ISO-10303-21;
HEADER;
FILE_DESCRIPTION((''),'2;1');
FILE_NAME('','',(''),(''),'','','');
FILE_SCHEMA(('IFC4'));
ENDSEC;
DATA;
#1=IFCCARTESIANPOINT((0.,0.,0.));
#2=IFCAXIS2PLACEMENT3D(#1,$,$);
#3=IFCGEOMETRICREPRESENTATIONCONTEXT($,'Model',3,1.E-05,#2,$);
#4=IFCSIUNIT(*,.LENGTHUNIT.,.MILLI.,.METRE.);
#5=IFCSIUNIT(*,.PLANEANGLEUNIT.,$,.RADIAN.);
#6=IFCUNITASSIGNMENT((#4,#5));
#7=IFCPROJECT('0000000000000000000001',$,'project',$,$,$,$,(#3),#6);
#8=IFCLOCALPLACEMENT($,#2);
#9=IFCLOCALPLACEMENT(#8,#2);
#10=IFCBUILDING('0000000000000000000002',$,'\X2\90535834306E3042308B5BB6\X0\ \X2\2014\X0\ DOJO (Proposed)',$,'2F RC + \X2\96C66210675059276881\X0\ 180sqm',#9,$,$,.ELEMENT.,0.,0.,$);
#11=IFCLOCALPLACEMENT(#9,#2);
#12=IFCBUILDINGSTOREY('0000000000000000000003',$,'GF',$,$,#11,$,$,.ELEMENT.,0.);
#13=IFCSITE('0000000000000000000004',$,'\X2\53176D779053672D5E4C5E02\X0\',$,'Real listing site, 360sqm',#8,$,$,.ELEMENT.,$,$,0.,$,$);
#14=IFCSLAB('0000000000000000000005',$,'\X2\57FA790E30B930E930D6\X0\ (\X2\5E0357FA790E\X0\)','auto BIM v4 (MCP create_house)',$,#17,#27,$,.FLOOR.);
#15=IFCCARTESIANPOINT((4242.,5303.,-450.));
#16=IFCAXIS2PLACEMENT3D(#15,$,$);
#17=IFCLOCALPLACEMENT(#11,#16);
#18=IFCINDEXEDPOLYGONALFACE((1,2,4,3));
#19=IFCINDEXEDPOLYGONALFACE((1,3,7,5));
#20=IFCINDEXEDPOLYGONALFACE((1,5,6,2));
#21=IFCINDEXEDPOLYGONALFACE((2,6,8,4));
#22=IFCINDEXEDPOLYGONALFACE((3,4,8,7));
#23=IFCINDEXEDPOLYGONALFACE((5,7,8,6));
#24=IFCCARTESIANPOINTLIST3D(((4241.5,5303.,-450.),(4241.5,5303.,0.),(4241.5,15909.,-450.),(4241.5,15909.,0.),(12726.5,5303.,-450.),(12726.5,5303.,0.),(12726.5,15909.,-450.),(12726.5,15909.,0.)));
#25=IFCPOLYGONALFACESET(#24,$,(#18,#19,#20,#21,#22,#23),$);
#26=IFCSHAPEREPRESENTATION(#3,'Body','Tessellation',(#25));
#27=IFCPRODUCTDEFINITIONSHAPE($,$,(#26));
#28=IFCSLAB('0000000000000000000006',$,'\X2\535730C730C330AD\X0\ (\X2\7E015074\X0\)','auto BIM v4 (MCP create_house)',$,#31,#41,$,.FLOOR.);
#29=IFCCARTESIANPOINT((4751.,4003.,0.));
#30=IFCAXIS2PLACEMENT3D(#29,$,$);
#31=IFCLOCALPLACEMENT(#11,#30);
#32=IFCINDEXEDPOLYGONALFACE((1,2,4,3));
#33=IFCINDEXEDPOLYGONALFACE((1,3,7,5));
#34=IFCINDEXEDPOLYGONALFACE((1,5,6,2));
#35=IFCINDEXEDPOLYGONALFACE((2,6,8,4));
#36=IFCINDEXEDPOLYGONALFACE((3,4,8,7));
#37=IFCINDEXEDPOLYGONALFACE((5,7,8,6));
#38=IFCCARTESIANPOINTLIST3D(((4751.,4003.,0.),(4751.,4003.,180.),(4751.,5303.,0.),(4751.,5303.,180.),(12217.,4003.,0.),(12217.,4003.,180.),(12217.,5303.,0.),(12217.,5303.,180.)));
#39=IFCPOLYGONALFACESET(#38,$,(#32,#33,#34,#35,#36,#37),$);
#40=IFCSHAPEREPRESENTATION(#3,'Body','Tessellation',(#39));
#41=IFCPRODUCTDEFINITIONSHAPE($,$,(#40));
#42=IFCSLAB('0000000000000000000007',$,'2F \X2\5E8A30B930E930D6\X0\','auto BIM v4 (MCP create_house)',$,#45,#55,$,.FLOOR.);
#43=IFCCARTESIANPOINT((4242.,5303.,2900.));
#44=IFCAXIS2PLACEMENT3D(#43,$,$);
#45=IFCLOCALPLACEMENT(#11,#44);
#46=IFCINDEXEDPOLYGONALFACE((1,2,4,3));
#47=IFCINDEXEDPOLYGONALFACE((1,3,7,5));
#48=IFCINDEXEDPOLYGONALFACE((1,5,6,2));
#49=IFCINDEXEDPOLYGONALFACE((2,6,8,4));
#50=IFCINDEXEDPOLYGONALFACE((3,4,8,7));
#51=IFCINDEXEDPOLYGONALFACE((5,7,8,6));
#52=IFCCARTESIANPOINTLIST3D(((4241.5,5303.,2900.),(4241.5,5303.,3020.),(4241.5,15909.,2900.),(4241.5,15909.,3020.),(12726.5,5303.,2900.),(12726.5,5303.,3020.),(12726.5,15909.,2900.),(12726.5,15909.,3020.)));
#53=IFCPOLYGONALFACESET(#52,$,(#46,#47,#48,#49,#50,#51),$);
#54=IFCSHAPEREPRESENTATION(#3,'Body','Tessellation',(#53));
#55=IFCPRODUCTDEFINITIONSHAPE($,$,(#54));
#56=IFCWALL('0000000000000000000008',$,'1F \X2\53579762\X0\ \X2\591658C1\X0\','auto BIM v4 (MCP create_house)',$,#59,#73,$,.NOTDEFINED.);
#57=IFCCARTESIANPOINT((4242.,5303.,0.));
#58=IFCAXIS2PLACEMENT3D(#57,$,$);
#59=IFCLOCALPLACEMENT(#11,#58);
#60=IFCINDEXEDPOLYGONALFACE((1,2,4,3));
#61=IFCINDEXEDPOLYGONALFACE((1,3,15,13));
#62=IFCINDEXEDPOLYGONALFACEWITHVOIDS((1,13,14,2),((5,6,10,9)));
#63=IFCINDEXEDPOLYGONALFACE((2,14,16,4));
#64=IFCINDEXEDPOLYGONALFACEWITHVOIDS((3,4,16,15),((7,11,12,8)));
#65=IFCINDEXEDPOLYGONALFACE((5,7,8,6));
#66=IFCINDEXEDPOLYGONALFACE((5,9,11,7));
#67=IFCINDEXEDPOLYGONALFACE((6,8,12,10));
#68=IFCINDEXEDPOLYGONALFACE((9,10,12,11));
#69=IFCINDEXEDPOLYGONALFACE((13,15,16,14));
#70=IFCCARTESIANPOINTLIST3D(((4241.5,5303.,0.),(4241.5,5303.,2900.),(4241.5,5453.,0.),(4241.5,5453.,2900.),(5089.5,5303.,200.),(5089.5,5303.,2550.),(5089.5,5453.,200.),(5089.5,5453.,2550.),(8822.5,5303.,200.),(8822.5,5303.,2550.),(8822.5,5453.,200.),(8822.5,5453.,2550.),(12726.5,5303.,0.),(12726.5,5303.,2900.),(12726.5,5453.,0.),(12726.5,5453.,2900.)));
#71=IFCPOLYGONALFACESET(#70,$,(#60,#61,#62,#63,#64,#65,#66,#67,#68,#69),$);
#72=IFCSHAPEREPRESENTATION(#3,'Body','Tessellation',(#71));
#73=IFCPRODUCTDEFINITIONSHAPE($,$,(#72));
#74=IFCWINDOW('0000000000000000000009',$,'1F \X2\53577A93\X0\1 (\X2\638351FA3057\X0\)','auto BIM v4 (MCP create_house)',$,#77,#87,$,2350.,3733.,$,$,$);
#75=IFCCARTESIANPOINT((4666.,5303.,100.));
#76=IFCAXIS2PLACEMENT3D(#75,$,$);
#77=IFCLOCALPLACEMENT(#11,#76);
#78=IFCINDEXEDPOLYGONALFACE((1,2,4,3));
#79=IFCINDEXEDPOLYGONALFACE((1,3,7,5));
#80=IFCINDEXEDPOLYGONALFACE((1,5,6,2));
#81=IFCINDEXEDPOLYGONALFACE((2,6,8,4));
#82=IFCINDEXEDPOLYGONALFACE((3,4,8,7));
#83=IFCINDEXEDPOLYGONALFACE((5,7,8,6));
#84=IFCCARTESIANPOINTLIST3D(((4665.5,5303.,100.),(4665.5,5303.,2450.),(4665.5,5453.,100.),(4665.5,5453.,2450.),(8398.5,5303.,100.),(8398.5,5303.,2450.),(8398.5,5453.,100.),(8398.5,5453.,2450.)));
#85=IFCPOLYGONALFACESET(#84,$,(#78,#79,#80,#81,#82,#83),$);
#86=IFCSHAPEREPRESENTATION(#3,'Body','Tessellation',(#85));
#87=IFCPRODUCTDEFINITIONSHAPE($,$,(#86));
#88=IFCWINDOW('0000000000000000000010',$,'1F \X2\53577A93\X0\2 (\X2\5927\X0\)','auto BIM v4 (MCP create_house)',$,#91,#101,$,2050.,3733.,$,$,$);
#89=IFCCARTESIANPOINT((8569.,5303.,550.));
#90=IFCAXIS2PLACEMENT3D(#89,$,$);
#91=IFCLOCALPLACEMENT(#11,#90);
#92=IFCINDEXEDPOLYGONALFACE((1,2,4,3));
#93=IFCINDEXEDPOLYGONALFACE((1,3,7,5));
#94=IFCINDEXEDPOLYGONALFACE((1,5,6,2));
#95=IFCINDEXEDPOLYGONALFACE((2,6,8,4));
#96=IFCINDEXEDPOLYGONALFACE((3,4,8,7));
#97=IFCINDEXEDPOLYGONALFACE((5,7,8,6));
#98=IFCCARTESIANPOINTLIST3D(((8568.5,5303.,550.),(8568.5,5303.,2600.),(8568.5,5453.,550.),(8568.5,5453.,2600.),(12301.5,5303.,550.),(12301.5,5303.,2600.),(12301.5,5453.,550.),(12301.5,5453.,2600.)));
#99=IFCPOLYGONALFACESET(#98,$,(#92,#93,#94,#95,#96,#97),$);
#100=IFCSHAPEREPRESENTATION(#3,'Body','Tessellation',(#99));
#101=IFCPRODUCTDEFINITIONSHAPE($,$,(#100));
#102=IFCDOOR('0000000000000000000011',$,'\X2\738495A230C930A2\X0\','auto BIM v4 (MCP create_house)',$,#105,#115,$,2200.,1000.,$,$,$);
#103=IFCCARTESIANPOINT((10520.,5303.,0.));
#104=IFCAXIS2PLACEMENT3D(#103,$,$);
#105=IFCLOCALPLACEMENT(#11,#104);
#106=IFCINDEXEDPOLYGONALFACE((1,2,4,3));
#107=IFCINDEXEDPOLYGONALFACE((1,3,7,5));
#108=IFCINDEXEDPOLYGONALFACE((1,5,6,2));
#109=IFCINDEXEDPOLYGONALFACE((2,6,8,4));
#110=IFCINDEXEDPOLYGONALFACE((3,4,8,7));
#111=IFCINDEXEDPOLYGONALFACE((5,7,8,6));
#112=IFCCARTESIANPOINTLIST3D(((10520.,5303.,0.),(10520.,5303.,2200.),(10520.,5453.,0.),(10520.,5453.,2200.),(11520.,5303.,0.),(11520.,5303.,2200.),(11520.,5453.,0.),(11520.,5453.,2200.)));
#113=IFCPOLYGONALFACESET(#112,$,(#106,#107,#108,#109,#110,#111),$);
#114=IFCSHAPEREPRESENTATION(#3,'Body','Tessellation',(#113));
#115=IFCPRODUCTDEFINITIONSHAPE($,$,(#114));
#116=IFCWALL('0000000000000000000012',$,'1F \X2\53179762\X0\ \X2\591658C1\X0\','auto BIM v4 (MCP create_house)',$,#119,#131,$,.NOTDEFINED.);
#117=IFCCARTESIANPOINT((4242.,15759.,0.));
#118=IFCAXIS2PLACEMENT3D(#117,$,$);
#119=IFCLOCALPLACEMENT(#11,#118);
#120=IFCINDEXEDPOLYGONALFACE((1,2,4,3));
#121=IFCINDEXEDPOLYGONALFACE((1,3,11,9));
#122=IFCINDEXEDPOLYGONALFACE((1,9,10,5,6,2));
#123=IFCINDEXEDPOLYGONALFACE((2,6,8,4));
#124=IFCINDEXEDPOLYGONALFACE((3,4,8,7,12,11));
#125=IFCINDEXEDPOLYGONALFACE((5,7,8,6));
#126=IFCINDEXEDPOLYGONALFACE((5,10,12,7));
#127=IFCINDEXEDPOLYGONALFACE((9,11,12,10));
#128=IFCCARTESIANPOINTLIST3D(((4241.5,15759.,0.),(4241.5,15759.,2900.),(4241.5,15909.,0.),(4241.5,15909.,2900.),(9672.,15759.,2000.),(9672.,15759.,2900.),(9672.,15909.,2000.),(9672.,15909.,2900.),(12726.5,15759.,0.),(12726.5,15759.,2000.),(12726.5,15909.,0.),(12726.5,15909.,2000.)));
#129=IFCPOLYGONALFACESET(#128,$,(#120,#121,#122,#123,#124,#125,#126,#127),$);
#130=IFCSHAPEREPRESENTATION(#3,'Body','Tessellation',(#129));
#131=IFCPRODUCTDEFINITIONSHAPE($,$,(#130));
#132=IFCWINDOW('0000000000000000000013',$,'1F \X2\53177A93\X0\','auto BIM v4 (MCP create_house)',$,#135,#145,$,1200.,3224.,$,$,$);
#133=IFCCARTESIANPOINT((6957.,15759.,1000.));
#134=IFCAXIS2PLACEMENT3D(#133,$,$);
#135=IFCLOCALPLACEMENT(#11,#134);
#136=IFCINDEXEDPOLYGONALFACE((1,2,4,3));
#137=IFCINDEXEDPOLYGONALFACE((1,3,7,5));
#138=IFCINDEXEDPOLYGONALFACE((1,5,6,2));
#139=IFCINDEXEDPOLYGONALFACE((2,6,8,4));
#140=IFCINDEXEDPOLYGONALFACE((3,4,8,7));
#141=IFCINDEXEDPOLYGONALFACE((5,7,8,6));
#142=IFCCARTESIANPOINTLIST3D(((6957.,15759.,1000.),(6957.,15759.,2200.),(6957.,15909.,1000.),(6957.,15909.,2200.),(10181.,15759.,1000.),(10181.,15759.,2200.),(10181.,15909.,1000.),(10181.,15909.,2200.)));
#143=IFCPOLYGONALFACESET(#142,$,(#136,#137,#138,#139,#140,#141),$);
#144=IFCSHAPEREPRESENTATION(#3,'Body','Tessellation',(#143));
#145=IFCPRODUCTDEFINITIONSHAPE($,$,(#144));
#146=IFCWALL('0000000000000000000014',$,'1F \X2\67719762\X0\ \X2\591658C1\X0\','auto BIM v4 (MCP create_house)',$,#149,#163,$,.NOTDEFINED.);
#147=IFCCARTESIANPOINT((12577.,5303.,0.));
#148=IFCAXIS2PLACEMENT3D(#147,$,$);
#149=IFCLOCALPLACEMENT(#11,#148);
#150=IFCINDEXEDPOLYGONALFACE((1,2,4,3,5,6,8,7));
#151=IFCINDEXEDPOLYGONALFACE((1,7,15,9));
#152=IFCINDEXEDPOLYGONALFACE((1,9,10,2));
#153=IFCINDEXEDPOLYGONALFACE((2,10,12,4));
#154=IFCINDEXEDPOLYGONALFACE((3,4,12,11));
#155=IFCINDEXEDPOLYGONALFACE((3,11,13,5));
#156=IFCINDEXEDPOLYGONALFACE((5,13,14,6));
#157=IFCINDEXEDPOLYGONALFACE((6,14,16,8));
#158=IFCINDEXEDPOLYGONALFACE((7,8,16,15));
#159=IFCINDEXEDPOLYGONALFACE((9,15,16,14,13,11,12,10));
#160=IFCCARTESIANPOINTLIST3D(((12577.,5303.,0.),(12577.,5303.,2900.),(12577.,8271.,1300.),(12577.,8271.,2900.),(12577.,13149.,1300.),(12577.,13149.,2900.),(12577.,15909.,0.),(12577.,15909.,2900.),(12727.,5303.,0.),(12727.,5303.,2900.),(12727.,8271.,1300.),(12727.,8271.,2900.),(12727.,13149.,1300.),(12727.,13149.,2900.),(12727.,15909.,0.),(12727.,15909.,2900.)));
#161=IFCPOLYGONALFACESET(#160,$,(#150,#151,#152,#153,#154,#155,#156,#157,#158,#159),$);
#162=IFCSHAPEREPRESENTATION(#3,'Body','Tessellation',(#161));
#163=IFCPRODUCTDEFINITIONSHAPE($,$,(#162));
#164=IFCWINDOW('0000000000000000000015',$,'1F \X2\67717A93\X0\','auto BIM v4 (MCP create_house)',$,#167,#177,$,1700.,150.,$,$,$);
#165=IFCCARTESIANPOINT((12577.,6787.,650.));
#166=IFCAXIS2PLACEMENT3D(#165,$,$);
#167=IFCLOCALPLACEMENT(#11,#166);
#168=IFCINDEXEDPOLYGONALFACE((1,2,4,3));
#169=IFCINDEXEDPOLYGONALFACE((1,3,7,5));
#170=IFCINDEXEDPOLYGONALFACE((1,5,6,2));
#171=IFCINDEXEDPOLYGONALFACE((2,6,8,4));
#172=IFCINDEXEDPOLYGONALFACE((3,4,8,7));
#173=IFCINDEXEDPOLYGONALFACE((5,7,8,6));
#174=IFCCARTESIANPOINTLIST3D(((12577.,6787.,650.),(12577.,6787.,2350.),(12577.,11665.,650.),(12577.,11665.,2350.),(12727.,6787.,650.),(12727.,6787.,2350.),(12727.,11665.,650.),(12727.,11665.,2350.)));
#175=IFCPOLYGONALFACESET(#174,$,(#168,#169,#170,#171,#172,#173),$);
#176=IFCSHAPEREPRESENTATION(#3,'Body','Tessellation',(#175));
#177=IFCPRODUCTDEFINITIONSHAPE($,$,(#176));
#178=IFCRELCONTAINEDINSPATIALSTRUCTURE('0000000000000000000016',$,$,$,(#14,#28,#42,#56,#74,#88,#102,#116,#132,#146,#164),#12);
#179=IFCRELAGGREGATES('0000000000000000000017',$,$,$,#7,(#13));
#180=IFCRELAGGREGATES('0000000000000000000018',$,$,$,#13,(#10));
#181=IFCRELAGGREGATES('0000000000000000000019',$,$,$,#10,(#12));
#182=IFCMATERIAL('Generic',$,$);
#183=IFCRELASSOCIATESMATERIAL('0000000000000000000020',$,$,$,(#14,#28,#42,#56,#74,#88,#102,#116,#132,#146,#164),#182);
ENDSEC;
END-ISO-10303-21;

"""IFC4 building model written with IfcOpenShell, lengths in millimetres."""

from ifc_helpers import new_model, si_unit, frame, frame_2d, origin, place, context, project, spatial, rectangle, extrude, material, element, fill, save


model = new_model("IFC4")

# Units and contexts
model_context = context("Model", 3, precision=1e-05, world=origin())
ifc_project = project(units=[si_unit("LENGTHUNIT", "METRE", prefix="MILLI"), si_unit("PLANEANGLEUNIT", "RADIAN")], contexts=[model_context])

# Site, building, storey
site_placement = place(None, origin())
site = spatial("IfcSite", under=ifc_project, at=site_placement, Name="北海道札幌市", ObjectType="Real listing site, 360sqm", CompositionType="ELEMENT", RefElevation=0.0)
building_placement = place(site_placement, origin())
building = spatial("IfcBuilding", under=site, at=building_placement, Name="道場のある家 — DOJO (Proposed)", ObjectType="2F RC + 集成材大梁 180sqm", CompositionType="ELEMENT", ElevationOfRefHeight=0.0, ElevationOfTerrain=0.0)
storey_placement = place(building_placement, origin())
storey = spatial("IfcBuildingStorey", under=building, at=storey_placement, Name="GF", CompositionType="ELEMENT", Elevation=0.0)

# Slabs
ifc_material = material(Name="Generic")
slab_1_placement = place(storey_placement, frame((4242.0, 5303.0, -450.0)))
element("IfcSlab", 1, at=slab_1_placement, inside=storey, material=ifc_material, Name="基礎スラブ (布基礎)", Description="auto BIM v4 (MCP create_house)", PredefinedType="FLOOR", context=model_context, shape_type="SweptSolid", body=[
    extrude(rectangle(XDim=8485.0, YDim=10606.0, at=frame_2d((4242.0, 5303.0))), frame((4242.0, 5303.0, -450.0)), (0.0, 0.0, 1.0), 450.0),
])
slab_2_placement = place(storey_placement, frame((4751.0, 4003.0, 0.0)))
element("IfcSlab", 2, at=slab_2_placement, inside=storey, material=ifc_material, Name="南デッキ (縁側)", Description="auto BIM v4 (MCP create_house)", PredefinedType="FLOOR", context=model_context, shape_type="SweptSolid", body=[
    extrude(rectangle(XDim=7466.0, YDim=1300.0, at=frame_2d((3733.0, 650.0))), frame((4751.0, 4003.0, 0.0)), (0.0, 0.0, 1.0), 180.0),
])
slab_3_placement = place(storey_placement, frame((4242.0, 5303.0, 2900.0)))
element("IfcSlab", 3, at=slab_3_placement, inside=storey, material=ifc_material, Name="2F 床スラブ", Description="auto BIM v4 (MCP create_house)", PredefinedType="FLOOR", context=model_context, shape_type="SweptSolid", body=[
    extrude(rectangle(XDim=8485.0, YDim=10606.0, at=frame_2d((4242.0, 5303.0))), frame((4242.0, 5303.0, 2900.0)), (0.0, 0.0, 1.0), 120.0),
])

# Wall, openings, windows, door
wall_1_placement = place(storey_placement, frame((4242.0, 5303.0, 0.0)))
wall_1 = element("IfcWall", 4, at=wall_1_placement, inside=storey, material=ifc_material, Name="1F 南面 外壁", Description="auto BIM v4 (MCP create_house)", PredefinedType="NOTDEFINED", context=model_context, shape_type="SweptSolid", body=[
    extrude(rectangle(XDim=8485.0, YDim=150.0, at=frame_2d((4242.0, 75.0))), frame((4242.0, 5303.0, 0.0)), (0.0, 0.0, 1.0), 2900.0),
])
opening_1_placement = place(storey_placement, frame((4666.0, 5303.0, 100.0)))
opening_1 = element("IfcOpeningElement", 5, at=opening_1_placement, cuts=wall_1, PredefinedType="NOTDEFINED", context=model_context, shape_type="SweptSolid", body=[
    extrude(rectangle(XDim=3733.0, YDim=150.0, at=frame_2d((1866.0, 75.0))), frame((4666.0, 5303.0, 100.0)), (0.0, 0.0, 1.0), 2350.0),
])
opening_2_placement = place(storey_placement, frame((8569.0, 5303.0, 550.0)))
opening_2 = element("IfcOpeningElement", 6, at=opening_2_placement, cuts=wall_1, PredefinedType="NOTDEFINED", context=model_context, shape_type="SweptSolid", body=[
    extrude(rectangle(XDim=3733.0, YDim=150.0, at=frame_2d((1866.0, 75.0))), frame((8569.0, 5303.0, 550.0)), (0.0, 0.0, 1.0), 2050.0),
])
opening_3_placement = place(storey_placement, frame((10520.0, 5303.0, 0.0)))
opening_3 = element("IfcOpeningElement", 7, at=opening_3_placement, cuts=wall_1, PredefinedType="NOTDEFINED", context=model_context, shape_type="SweptSolid", body=[
    extrude(rectangle(XDim=1000.0, YDim=150.0, at=frame_2d((500.0, 75.0))), frame((10520.0, 5303.0, 0.0)), (0.0, 0.0, 1.0), 2200.0),
])
window_1_placement = place(storey_placement, frame((4666.0, 5303.0, 100.0)))
window_1 = element("IfcWindow", 8, at=window_1_placement, inside=storey, material=ifc_material, Name="1F 南窓1 (掃出し)", Description="auto BIM v4 (MCP create_house)", OverallHeight=2350.0, OverallWidth=3733.0, context=model_context, shape_type="SweptSolid", body=[
    extrude(rectangle(XDim=3733.0, YDim=150.0, at=frame_2d((1866.0, 75.0))), frame((4666.0, 5303.0, 100.0)), (0.0, 0.0, 1.0), 2350.0),
])
fill(opening_1, window_1)
window_2_placement = place(storey_placement, frame((8569.0, 5303.0, 550.0)))
window_2 = element("IfcWindow", 9, at=window_2_placement, inside=storey, material=ifc_material, Name="1F 南窓2 (大)", Description="auto BIM v4 (MCP create_house)", OverallHeight=2050.0, OverallWidth=3733.0, context=model_context, shape_type="SweptSolid", body=[
    extrude(rectangle(XDim=3733.0, YDim=150.0, at=frame_2d((1866.0, 75.0))), frame((8569.0, 5303.0, 550.0)), (0.0, 0.0, 1.0), 2050.0),
])
fill(opening_2, window_2)
door_1_placement = place(storey_placement, frame((10520.0, 5303.0, 0.0)))
door_1 = element("IfcDoor", 10, at=door_1_placement, inside=storey, material=ifc_material, Name="玄関ドア", Description="auto BIM v4 (MCP create_house)", OverallHeight=2200.0, OverallWidth=1000.0, context=model_context, shape_type="SweptSolid", body=[
    extrude(rectangle(XDim=1000.0, YDim=150.0, at=frame_2d((500.0, 75.0))), frame((10520.0, 5303.0, 0.0)), (0.0, 0.0, 1.0), 2200.0),
])
fill(opening_3, door_1)

# Walls, openings, windows
wall_2_placement = place(storey_placement, frame((4242.0, 15759.0, 0.0)))
wall_2 = element("IfcWall", 11, at=wall_2_placement, inside=storey, material=ifc_material, Name="1F 北面 外壁", Description="auto BIM v4 (MCP create_house)", PredefinedType="NOTDEFINED", context=model_context, shape_type="SweptSolid", body=[
    extrude(rectangle(XDim=8485.0, YDim=150.0, at=frame_2d((4242.0, 75.0))), frame((4242.0, 15759.0, 0.0)), (0.0, 0.0, 1.0), 2900.0),
])
opening_4_placement = place(storey_placement, frame((6957.0, 15759.0, 1000.0)))
opening_4 = element("IfcOpeningElement", 12, at=opening_4_placement, cuts=wall_2, PredefinedType="NOTDEFINED", context=model_context, shape_type="SweptSolid", body=[
    extrude(rectangle(XDim=3224.0, YDim=150.0, at=frame_2d((1612.0, 75.0))), frame((6957.0, 15759.0, 1000.0)), (0.0, 0.0, 1.0), 1200.0),
])
window_3_placement = place(storey_placement, frame((6957.0, 15759.0, 1000.0)))
window_3 = element("IfcWindow", 13, at=window_3_placement, inside=storey, material=ifc_material, Name="1F 北窓", Description="auto BIM v4 (MCP create_house)", OverallHeight=1200.0, OverallWidth=3224.0, context=model_context, shape_type="SweptSolid", body=[
    extrude(rectangle(XDim=3224.0, YDim=150.0, at=frame_2d((1612.0, 75.0))), frame((6957.0, 15759.0, 1000.0)), (0.0, 0.0, 1.0), 1200.0),
])
fill(opening_4, window_3)
wall_3_placement = place(storey_placement, frame((12577.0, 5303.0, 0.0)))
wall_3 = element("IfcWall", 14, at=wall_3_placement, inside=storey, material=ifc_material, Name="1F 東面 外壁", Description="auto BIM v4 (MCP create_house)", PredefinedType="NOTDEFINED", context=model_context, shape_type="SweptSolid", body=[
    extrude(rectangle(XDim=150.0, YDim=10606.0, at=frame_2d((75.0, 5303.0))), frame((12577.0, 5303.0, 0.0)), (0.0, 0.0, 1.0), 2900.0),
])
opening_5_placement = place(storey_placement, frame((12577.0, 6787.0, 650.0)))
opening_5 = element("IfcOpeningElement", 15, at=opening_5_placement, cuts=wall_3, PredefinedType="NOTDEFINED", context=model_context, shape_type="SweptSolid", body=[
    extrude(rectangle(XDim=150.0, YDim=4878.0, at=frame_2d((75.0, 2439.0))), frame((12577.0, 6787.0, 650.0)), (0.0, 0.0, 1.0), 1700.0),
])
window_4_placement = place(storey_placement, frame((12577.0, 6787.0, 650.0)))
window_4 = element("IfcWindow", 16, at=window_4_placement, inside=storey, material=ifc_material, Name="1F 東窓", Description="auto BIM v4 (MCP create_house)", OverallHeight=1700.0, OverallWidth=150.0, context=model_context, shape_type="SweptSolid", body=[
    extrude(rectangle(XDim=150.0, YDim=4878.0, at=frame_2d((75.0, 2439.0))), frame((12577.0, 6787.0, 650.0)), (0.0, 0.0, 1.0), 1700.0),
])
fill(opening_5, window_4)

save(model, "model.ifc")
